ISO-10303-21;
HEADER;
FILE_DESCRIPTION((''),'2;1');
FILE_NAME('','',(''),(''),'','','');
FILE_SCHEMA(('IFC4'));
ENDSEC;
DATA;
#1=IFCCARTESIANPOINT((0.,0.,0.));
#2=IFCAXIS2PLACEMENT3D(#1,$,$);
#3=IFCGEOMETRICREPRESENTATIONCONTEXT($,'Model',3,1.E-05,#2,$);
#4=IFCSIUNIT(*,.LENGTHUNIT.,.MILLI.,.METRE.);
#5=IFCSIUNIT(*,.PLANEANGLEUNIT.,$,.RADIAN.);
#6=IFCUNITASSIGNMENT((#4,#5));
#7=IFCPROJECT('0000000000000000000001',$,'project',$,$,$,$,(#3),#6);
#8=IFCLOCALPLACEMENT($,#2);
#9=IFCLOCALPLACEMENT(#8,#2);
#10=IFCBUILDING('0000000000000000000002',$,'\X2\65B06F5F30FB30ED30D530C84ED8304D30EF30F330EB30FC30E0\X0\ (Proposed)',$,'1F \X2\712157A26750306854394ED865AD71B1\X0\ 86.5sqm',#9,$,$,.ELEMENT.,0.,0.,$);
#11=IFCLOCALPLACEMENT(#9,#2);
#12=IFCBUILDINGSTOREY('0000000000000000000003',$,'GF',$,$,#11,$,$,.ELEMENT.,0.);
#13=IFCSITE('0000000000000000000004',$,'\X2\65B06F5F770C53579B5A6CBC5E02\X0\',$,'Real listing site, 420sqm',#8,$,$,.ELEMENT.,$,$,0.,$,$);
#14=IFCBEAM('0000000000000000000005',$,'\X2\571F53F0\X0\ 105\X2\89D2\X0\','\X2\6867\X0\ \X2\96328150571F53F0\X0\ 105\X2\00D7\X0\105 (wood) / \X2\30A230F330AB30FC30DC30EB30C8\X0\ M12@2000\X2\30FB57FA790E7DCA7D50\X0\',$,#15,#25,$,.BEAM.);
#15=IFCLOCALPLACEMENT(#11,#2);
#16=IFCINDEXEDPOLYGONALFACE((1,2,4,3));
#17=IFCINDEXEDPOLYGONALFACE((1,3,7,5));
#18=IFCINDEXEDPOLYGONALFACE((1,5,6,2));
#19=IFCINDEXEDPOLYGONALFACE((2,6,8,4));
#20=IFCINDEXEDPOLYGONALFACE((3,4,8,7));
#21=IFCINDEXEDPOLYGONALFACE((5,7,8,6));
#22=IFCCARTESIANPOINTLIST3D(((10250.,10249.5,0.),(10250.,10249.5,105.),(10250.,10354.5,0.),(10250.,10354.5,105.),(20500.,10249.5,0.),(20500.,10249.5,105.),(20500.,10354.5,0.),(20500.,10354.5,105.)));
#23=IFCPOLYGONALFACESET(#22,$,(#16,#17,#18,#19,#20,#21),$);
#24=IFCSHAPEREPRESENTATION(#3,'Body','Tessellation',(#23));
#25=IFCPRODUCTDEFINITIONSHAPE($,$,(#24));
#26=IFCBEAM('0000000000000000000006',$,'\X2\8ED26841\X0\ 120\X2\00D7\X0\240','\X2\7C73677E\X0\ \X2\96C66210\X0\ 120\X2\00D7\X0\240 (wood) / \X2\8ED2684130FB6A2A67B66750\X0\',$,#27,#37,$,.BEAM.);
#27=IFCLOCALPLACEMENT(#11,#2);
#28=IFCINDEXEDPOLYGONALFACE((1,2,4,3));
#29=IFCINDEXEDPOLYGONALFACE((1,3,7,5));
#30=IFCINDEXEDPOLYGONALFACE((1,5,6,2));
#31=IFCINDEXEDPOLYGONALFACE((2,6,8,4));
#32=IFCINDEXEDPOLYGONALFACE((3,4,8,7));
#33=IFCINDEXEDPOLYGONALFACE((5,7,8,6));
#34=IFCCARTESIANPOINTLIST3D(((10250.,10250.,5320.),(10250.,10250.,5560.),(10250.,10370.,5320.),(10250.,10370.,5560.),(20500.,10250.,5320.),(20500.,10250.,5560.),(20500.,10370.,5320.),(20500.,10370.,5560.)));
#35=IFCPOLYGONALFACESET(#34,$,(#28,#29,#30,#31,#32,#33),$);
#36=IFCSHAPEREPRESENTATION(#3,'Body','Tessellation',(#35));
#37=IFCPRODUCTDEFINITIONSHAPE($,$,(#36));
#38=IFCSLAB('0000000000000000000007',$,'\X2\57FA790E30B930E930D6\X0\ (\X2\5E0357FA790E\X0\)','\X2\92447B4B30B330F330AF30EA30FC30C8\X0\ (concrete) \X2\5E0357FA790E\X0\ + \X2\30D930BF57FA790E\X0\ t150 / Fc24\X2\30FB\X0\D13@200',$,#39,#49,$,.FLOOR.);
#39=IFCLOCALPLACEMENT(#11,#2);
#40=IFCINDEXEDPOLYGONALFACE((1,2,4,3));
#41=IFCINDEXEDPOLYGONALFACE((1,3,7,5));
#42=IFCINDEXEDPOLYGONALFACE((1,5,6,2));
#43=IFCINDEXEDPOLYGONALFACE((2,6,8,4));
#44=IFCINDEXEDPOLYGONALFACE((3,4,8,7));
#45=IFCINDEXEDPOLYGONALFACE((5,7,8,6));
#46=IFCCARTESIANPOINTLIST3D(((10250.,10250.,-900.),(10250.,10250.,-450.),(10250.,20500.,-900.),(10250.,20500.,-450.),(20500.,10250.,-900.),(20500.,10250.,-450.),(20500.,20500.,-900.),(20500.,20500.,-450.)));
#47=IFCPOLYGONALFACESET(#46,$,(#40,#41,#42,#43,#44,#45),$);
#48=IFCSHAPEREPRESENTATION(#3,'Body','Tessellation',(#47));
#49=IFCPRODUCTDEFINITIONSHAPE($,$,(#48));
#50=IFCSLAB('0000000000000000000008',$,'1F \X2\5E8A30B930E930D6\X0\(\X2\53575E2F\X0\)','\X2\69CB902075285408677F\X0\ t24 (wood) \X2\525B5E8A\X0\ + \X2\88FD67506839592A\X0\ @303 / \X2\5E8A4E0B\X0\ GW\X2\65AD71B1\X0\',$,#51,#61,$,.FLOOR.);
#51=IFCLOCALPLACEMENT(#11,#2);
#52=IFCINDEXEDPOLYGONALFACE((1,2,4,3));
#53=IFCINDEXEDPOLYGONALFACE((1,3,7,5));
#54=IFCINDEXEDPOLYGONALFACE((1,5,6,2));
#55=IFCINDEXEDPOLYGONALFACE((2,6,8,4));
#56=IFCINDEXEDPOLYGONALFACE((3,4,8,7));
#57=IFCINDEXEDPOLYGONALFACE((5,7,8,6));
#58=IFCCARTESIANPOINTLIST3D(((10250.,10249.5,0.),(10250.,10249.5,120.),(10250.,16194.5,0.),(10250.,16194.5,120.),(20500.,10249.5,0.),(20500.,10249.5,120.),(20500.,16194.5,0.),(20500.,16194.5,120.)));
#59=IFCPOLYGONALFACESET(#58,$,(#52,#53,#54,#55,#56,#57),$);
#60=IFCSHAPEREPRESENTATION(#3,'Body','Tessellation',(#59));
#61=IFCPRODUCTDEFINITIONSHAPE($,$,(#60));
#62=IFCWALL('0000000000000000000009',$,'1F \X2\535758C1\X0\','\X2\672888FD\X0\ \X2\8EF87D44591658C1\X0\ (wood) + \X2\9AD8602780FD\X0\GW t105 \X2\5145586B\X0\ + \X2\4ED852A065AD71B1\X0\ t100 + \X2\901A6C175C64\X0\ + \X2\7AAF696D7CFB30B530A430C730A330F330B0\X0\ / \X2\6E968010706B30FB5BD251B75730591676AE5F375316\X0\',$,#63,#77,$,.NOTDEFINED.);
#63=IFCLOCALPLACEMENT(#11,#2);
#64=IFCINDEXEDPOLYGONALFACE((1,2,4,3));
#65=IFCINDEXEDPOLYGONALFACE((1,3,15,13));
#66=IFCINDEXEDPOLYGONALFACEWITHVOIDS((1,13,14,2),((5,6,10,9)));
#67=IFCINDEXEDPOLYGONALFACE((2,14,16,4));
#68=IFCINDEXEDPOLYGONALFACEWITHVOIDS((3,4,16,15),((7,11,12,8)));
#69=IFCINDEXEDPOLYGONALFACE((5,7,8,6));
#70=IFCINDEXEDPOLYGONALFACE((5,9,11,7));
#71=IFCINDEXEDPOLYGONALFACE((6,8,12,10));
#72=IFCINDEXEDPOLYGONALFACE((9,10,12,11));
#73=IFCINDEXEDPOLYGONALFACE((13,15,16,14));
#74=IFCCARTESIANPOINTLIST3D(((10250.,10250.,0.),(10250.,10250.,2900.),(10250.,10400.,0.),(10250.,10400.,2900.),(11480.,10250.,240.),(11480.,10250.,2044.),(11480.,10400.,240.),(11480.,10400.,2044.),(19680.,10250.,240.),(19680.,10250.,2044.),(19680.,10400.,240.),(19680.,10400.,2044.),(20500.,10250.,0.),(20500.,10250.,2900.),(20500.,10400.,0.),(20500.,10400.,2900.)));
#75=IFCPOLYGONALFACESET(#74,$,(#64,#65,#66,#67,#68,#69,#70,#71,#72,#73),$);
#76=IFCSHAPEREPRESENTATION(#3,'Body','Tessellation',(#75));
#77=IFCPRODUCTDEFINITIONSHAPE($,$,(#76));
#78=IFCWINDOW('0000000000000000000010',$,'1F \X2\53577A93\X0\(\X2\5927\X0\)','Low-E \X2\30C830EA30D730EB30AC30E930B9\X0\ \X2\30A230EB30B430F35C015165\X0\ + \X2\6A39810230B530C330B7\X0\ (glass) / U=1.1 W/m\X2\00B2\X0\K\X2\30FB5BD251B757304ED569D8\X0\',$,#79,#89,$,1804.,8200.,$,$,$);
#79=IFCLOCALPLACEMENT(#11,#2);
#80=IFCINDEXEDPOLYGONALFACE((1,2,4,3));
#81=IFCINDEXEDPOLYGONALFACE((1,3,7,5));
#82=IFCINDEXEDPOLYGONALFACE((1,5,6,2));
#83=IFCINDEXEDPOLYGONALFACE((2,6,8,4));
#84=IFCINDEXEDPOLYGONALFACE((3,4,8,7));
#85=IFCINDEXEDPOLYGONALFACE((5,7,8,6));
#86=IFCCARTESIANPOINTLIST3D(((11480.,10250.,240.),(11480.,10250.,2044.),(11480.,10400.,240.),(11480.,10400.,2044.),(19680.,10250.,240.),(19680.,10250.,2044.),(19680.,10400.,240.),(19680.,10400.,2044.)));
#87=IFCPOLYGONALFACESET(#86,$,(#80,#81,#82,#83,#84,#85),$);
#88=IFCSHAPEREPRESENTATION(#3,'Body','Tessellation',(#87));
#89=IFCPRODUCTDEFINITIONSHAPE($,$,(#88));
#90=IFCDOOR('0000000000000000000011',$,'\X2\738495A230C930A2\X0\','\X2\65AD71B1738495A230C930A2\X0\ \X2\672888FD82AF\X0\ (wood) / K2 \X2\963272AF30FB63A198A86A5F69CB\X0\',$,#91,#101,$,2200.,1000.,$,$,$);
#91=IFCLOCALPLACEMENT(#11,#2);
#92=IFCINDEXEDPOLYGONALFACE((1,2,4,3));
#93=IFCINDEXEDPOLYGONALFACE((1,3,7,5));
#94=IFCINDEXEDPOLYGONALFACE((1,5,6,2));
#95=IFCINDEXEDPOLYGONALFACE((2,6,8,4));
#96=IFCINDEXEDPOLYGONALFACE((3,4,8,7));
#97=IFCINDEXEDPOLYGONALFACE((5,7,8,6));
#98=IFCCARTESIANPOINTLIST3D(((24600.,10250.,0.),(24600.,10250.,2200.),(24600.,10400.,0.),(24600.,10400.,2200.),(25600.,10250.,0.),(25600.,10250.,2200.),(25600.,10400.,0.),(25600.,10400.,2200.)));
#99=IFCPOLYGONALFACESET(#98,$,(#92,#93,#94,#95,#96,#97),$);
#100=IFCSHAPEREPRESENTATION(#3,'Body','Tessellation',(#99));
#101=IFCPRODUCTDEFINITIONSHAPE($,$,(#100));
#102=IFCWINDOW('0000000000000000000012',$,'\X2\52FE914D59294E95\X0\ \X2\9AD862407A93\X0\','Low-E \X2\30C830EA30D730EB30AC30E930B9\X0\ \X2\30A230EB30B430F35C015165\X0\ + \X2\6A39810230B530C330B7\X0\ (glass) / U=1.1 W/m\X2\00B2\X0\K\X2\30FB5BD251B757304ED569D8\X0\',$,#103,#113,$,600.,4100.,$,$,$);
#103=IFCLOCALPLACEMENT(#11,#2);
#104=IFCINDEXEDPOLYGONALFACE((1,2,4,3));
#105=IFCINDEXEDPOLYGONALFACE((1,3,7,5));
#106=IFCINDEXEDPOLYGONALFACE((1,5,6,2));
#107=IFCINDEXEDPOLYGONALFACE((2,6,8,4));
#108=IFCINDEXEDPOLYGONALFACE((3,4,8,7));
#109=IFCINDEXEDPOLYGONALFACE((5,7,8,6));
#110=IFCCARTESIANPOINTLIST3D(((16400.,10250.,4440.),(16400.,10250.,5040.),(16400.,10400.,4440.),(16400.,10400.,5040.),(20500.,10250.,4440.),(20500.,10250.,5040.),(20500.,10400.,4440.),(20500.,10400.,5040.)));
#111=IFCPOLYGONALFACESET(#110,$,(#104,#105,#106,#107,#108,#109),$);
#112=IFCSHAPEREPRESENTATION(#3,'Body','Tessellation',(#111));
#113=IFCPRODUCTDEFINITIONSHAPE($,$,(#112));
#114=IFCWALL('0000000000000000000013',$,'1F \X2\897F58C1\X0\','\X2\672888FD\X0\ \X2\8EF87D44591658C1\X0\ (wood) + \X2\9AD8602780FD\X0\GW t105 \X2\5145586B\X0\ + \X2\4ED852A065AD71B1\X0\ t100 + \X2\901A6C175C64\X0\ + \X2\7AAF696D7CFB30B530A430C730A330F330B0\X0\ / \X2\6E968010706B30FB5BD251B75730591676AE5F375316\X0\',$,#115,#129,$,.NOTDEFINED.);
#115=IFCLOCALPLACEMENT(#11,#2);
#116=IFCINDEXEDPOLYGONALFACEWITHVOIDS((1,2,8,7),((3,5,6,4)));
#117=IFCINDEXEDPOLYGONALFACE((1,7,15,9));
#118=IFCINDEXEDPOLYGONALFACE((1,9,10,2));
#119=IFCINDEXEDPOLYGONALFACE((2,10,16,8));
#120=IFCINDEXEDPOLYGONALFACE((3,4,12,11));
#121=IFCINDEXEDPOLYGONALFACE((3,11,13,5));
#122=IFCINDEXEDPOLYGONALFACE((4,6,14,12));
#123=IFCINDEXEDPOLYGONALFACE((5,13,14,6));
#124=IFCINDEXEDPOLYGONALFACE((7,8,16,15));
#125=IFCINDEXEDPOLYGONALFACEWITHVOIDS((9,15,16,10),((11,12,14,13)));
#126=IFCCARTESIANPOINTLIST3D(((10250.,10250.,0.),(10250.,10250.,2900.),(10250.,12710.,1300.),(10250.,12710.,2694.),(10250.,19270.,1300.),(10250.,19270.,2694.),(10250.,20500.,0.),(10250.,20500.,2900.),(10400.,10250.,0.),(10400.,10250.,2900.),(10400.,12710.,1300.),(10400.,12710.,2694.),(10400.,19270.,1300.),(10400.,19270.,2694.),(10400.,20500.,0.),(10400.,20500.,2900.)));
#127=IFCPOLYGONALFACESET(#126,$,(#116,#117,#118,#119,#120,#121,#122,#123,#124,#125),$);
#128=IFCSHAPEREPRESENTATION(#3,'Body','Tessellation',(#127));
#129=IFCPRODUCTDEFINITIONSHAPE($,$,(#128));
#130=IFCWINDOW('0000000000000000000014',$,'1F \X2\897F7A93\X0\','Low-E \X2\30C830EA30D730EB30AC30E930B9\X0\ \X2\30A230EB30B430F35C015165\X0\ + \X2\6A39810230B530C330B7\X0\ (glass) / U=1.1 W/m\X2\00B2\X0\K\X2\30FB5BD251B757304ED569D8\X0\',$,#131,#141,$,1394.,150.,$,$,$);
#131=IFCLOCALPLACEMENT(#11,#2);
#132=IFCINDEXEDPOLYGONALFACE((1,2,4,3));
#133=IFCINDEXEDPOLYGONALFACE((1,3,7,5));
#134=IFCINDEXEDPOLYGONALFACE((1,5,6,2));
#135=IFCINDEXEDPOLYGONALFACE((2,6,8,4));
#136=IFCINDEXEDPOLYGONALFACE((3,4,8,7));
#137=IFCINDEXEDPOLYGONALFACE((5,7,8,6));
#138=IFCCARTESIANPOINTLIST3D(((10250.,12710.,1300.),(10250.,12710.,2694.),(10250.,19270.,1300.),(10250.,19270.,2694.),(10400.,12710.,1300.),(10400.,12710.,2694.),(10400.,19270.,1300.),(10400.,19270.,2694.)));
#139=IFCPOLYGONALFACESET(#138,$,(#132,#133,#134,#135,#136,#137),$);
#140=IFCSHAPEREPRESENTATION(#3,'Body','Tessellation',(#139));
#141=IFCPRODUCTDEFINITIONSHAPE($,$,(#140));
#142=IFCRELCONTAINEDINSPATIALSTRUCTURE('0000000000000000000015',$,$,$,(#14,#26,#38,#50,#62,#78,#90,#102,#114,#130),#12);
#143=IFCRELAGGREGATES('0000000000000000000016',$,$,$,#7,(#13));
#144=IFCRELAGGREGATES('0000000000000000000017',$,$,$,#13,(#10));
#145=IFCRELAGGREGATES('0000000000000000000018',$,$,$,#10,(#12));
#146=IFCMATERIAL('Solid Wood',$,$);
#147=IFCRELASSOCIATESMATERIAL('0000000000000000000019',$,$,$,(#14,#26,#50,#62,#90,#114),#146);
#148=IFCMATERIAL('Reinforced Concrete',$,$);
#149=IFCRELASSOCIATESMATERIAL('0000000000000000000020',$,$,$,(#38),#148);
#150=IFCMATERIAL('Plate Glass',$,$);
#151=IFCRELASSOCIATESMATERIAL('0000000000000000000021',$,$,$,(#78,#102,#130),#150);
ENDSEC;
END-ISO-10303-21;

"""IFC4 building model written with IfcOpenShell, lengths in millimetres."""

from ifc_helpers import new_model, si_unit, frame, frame_2d, origin, place, context, project, spatial, rectangle, extrude, material, element, fill, save


model = new_model("IFC4")

# Units and contexts
model_context = context("Model", 3, precision=1e-05, world=origin())
ifc_project = project(units=[si_unit("LENGTHUNIT", "METRE", prefix="MILLI"), si_unit("PLANEANGLEUNIT", "RADIAN")], contexts=[model_context])

# Site, building, storey
site_placement = place(None, origin())
site = spatial("IfcSite", under=ifc_project, at=site_placement, Name="新潟県南魚沼市", ObjectType="Real listing site, 420sqm", CompositionType="ELEMENT", RefElevation=0.0)
building_placement = place(site_placement, origin())
building = spatial("IfcBuilding", under=site, at=building_placement, Name="新潟・ロフト付きワンルーム (Proposed)", ObjectType="1F 無垢材と吹付断熱 86.5sqm", CompositionType="ELEMENT", ElevationOfRefHeight=0.0, ElevationOfTerrain=0.0)
storey_placement = place(building_placement, origin())
storey = spatial("IfcBuildingStorey", under=building, at=storey_placement, Name="GF", CompositionType="ELEMENT", Elevation=0.0)

# Shared definitions
ifc_material_1 = material(Name="Solid Wood")

# Beams
beam_1_placement = place(storey_placement, frame((5125.0, 5125.0, 0.0)))
element("IfcBeam", 1, at=beam_1_placement, inside=storey, material=ifc_material_1, Name="土台 105角", Description="桧 防腐土台 105×105 (wood) / アンカーボルト M12@2000・基礎緊結", PredefinedType="BEAM", context=model_context, shape_type="SweptSolid", body=[
    extrude(rectangle(XDim=10250.0, YDim=105.0, at=frame_2d((5125.0, 52.0))), frame((5125.0, 5125.0, 0.0)), (0.0, 0.0, 1.0), 105.0),
])
beam_2_placement = place(storey_placement, frame((5125.0, 5125.0, 2660.0)))
element("IfcBeam", 2, at=beam_2_placement, inside=storey, material=ifc_material_1, Name="軒桁 120×240", Description="米松 集成 120×240 (wood) / 軒桁・横架材", PredefinedType="BEAM", context=model_context, shape_type="SweptSolid", body=[
    extrude(rectangle(XDim=10250.0, YDim=120.0, at=frame_2d((5125.0, 60.0))), frame((5125.0, 5125.0, 2660.0)), (0.0, 0.0, 1.0), 240.0),
])

# Slabs
ifc_material_2 = material(Name="Reinforced Concrete")
slab_1_placement = place(storey_placement, frame((5125.0, 5125.0, -450.0)))
element("IfcSlab", 3, at=slab_1_placement, inside=storey, material=ifc_material_2, Name="基礎スラブ (布基礎)", Description="鉄筋コンクリート (concrete) 布基礎 + ベタ基礎 t150 / Fc24・D13@200", PredefinedType="FLOOR", context=model_context, shape_type="SweptSolid", body=[
    extrude(rectangle(XDim=10250.0, YDim=10250.0, at=frame_2d((5125.0, 5125.0))), frame((5125.0, 5125.0, -450.0)), (0.0, 0.0, 1.0), 450.0),
])
slab_2_placement = place(storey_placement, frame((5125.0, 5125.0, 0.0)))
element("IfcSlab", 4, at=slab_2_placement, inside=storey, material=ifc_material_1, Name="1F 床スラブ(南帯)", Description="構造用合板 t24 (wood) 剛床 + 製材根太 @303 / 床下 GW断熱", PredefinedType="FLOOR", context=model_context, shape_type="SweptSolid", body=[
    extrude(rectangle(XDim=10250.0, YDim=5945.0, at=frame_2d((5125.0, 2972.0))), frame((5125.0, 5125.0, 0.0)), (0.0, 0.0, 1.0), 120.0),
])

# Wall, openings, windows, door
wall_1_placement = place(storey_placement, frame((5125.0, 5125.0, 0.0)))
wall_1 = element("IfcWall", 5, at=wall_1_placement, inside=storey, material=ifc_material_1, Name="1F 南壁", Description="木製 軸組外壁 (wood) + 高性能GW t105 充填 + 付加断熱 t100 + 通気層 + 窯業系サイディング / 準耐火・寒冷地外皮強化", PredefinedType="NOTDEFINED", context=model_context, shape_type="SweptSolid", body=[
    extrude(rectangle(XDim=10250.0, YDim=150.0, at=frame_2d((5125.0, 75.0))), frame((5125.0, 5125.0, 0.0)), (0.0, 0.0, 1.0), 2900.0),
])
opening_1_placement = place(storey_placement, frame((5740.0, 5125.0, 120.0)))
opening_1 = element("IfcOpeningElement", 6, at=opening_1_placement, cuts=wall_1, PredefinedType="NOTDEFINED", context=model_context, shape_type="SweptSolid", body=[
    extrude(rectangle(XDim=8200.0, YDim=150.0, at=frame_2d((4100.0, 75.0))), frame((5740.0, 5125.0, 120.0)), (0.0, 0.0, 1.0), 1804.0),
])
opening_2_placement = place(storey_placement, frame((12300.0, 5125.0, 0.0)))
opening_2 = element("IfcOpeningElement", 7, at=opening_2_placement, cuts=wall_1, PredefinedType="NOTDEFINED", context=model_context, shape_type="SweptSolid", body=[
    extrude(rectangle(XDim=1000.0, YDim=150.0, at=frame_2d((500.0, 75.0))), frame((12300.0, 5125.0, 0.0)), (0.0, 0.0, 1.0), 2200.0),
])
opening_3_placement = place(storey_placement, frame((8200.0, 5125.0, 2220.0)))
opening_3 = element("IfcOpeningElement", 8, at=opening_3_placement, cuts=wall_1, PredefinedType="NOTDEFINED", context=model_context, shape_type="SweptSolid", body=[
    extrude(rectangle(XDim=4100.0, YDim=150.0, at=frame_2d((2050.0, 75.0))), frame((8200.0, 5125.0, 2220.0)), (0.0, 0.0, 1.0), 600.0),
])
ifc_material_3 = material(Name="Plate Glass")
window_1_placement = place(storey_placement, frame((5740.0, 5125.0, 120.0)))
window_1 = element("IfcWindow", 9, at=window_1_placement, inside=storey, material=ifc_material_3, Name="1F 南窓(大)", Description="Low-E トリプルガラス アルゴン封入 + 樹脂サッシ (glass) / U=1.1 W/m²K・寒冷地仕様", OverallHeight=1804.0, OverallWidth=8200.0, context=model_context, shape_type="SweptSolid", body=[
    extrude(rectangle(XDim=8200.0, YDim=150.0, at=frame_2d((4100.0, 75.0))), frame((5740.0, 5125.0, 120.0)), (0.0, 0.0, 1.0), 1804.0),
])
fill(opening_1, window_1)
door_1_placement = place(storey_placement, frame((12300.0, 5125.0, 0.0)))
door_1 = element("IfcDoor", 10, at=door_1_placement, inside=storey, material=ifc_material_1, Name="玄関ドア", Description="断熱玄関ドア 木製芯 (wood) / K2 防犯・採風機構", OverallHeight=2200.0, OverallWidth=1000.0, context=model_context, shape_type="SweptSolid", body=[
    extrude(rectangle(XDim=1000.0, YDim=150.0, at=frame_2d((500.0, 75.0))), frame((12300.0, 5125.0, 0.0)), (0.0, 0.0, 1.0), 2200.0),
])
fill(opening_2, door_1)
window_2_placement = place(storey_placement, frame((8200.0, 5125.0, 2220.0)))
window_2 = element("IfcWindow", 11, at=window_2_placement, inside=storey, material=ifc_material_3, Name="勾配天井 高所窓", Description="Low-E トリプルガラス アルゴン封入 + 樹脂サッシ (glass) / U=1.1 W/m²K・寒冷地仕様", OverallHeight=600.0, OverallWidth=4100.0, context=model_context, shape_type="SweptSolid", body=[
    extrude(rectangle(XDim=4100.0, YDim=150.0, at=frame_2d((2050.0, 75.0))), frame((8200.0, 5125.0, 2220.0)), (0.0, 0.0, 1.0), 600.0),
])
fill(opening_3, window_2)

# Wall, opening, window
wall_2_placement = place(storey_placement, frame((5125.0, 5125.0, 0.0)))
wall_2 = element("IfcWall", 12, at=wall_2_placement, inside=storey, material=ifc_material_1, Name="1F 西壁", Description="木製 軸組外壁 (wood) + 高性能GW t105 充填 + 付加断熱 t100 + 通気層 + 窯業系サイディング / 準耐火・寒冷地外皮強化", PredefinedType="NOTDEFINED", context=model_context, shape_type="SweptSolid", body=[
    extrude(rectangle(XDim=150.0, YDim=10250.0, at=frame_2d((75.0, 5125.0))), frame((5125.0, 5125.0, 0.0)), (0.0, 0.0, 1.0), 2900.0),
])
opening_4_placement = place(storey_placement, frame((5125.0, 6355.0, 650.0)))
opening_4 = element("IfcOpeningElement", 13, at=opening_4_placement, cuts=wall_2, PredefinedType="NOTDEFINED", context=model_context, shape_type="SweptSolid", body=[
    extrude(rectangle(XDim=150.0, YDim=6560.0, at=frame_2d((75.0, 3280.0))), frame((5125.0, 6355.0, 650.0)), (0.0, 0.0, 1.0), 1394.0),
])
window_3_placement = place(storey_placement, frame((5125.0, 6355.0, 650.0)))
window_3 = element("IfcWindow", 14, at=window_3_placement, inside=storey, material=ifc_material_3, Name="1F 西窓", Description="Low-E トリプルガラス アルゴン封入 + 樹脂サッシ (glass) / U=1.1 W/m²K・寒冷地仕様", OverallHeight=1394.0, OverallWidth=150.0, context=model_context, shape_type="SweptSolid", body=[
    extrude(rectangle(XDim=150.0, YDim=6560.0, at=frame_2d((75.0, 3280.0))), frame((5125.0, 6355.0, 650.0)), (0.0, 0.0, 1.0), 1394.0),
])
fill(opening_4, window_3)

save(model, "model.ifc")
